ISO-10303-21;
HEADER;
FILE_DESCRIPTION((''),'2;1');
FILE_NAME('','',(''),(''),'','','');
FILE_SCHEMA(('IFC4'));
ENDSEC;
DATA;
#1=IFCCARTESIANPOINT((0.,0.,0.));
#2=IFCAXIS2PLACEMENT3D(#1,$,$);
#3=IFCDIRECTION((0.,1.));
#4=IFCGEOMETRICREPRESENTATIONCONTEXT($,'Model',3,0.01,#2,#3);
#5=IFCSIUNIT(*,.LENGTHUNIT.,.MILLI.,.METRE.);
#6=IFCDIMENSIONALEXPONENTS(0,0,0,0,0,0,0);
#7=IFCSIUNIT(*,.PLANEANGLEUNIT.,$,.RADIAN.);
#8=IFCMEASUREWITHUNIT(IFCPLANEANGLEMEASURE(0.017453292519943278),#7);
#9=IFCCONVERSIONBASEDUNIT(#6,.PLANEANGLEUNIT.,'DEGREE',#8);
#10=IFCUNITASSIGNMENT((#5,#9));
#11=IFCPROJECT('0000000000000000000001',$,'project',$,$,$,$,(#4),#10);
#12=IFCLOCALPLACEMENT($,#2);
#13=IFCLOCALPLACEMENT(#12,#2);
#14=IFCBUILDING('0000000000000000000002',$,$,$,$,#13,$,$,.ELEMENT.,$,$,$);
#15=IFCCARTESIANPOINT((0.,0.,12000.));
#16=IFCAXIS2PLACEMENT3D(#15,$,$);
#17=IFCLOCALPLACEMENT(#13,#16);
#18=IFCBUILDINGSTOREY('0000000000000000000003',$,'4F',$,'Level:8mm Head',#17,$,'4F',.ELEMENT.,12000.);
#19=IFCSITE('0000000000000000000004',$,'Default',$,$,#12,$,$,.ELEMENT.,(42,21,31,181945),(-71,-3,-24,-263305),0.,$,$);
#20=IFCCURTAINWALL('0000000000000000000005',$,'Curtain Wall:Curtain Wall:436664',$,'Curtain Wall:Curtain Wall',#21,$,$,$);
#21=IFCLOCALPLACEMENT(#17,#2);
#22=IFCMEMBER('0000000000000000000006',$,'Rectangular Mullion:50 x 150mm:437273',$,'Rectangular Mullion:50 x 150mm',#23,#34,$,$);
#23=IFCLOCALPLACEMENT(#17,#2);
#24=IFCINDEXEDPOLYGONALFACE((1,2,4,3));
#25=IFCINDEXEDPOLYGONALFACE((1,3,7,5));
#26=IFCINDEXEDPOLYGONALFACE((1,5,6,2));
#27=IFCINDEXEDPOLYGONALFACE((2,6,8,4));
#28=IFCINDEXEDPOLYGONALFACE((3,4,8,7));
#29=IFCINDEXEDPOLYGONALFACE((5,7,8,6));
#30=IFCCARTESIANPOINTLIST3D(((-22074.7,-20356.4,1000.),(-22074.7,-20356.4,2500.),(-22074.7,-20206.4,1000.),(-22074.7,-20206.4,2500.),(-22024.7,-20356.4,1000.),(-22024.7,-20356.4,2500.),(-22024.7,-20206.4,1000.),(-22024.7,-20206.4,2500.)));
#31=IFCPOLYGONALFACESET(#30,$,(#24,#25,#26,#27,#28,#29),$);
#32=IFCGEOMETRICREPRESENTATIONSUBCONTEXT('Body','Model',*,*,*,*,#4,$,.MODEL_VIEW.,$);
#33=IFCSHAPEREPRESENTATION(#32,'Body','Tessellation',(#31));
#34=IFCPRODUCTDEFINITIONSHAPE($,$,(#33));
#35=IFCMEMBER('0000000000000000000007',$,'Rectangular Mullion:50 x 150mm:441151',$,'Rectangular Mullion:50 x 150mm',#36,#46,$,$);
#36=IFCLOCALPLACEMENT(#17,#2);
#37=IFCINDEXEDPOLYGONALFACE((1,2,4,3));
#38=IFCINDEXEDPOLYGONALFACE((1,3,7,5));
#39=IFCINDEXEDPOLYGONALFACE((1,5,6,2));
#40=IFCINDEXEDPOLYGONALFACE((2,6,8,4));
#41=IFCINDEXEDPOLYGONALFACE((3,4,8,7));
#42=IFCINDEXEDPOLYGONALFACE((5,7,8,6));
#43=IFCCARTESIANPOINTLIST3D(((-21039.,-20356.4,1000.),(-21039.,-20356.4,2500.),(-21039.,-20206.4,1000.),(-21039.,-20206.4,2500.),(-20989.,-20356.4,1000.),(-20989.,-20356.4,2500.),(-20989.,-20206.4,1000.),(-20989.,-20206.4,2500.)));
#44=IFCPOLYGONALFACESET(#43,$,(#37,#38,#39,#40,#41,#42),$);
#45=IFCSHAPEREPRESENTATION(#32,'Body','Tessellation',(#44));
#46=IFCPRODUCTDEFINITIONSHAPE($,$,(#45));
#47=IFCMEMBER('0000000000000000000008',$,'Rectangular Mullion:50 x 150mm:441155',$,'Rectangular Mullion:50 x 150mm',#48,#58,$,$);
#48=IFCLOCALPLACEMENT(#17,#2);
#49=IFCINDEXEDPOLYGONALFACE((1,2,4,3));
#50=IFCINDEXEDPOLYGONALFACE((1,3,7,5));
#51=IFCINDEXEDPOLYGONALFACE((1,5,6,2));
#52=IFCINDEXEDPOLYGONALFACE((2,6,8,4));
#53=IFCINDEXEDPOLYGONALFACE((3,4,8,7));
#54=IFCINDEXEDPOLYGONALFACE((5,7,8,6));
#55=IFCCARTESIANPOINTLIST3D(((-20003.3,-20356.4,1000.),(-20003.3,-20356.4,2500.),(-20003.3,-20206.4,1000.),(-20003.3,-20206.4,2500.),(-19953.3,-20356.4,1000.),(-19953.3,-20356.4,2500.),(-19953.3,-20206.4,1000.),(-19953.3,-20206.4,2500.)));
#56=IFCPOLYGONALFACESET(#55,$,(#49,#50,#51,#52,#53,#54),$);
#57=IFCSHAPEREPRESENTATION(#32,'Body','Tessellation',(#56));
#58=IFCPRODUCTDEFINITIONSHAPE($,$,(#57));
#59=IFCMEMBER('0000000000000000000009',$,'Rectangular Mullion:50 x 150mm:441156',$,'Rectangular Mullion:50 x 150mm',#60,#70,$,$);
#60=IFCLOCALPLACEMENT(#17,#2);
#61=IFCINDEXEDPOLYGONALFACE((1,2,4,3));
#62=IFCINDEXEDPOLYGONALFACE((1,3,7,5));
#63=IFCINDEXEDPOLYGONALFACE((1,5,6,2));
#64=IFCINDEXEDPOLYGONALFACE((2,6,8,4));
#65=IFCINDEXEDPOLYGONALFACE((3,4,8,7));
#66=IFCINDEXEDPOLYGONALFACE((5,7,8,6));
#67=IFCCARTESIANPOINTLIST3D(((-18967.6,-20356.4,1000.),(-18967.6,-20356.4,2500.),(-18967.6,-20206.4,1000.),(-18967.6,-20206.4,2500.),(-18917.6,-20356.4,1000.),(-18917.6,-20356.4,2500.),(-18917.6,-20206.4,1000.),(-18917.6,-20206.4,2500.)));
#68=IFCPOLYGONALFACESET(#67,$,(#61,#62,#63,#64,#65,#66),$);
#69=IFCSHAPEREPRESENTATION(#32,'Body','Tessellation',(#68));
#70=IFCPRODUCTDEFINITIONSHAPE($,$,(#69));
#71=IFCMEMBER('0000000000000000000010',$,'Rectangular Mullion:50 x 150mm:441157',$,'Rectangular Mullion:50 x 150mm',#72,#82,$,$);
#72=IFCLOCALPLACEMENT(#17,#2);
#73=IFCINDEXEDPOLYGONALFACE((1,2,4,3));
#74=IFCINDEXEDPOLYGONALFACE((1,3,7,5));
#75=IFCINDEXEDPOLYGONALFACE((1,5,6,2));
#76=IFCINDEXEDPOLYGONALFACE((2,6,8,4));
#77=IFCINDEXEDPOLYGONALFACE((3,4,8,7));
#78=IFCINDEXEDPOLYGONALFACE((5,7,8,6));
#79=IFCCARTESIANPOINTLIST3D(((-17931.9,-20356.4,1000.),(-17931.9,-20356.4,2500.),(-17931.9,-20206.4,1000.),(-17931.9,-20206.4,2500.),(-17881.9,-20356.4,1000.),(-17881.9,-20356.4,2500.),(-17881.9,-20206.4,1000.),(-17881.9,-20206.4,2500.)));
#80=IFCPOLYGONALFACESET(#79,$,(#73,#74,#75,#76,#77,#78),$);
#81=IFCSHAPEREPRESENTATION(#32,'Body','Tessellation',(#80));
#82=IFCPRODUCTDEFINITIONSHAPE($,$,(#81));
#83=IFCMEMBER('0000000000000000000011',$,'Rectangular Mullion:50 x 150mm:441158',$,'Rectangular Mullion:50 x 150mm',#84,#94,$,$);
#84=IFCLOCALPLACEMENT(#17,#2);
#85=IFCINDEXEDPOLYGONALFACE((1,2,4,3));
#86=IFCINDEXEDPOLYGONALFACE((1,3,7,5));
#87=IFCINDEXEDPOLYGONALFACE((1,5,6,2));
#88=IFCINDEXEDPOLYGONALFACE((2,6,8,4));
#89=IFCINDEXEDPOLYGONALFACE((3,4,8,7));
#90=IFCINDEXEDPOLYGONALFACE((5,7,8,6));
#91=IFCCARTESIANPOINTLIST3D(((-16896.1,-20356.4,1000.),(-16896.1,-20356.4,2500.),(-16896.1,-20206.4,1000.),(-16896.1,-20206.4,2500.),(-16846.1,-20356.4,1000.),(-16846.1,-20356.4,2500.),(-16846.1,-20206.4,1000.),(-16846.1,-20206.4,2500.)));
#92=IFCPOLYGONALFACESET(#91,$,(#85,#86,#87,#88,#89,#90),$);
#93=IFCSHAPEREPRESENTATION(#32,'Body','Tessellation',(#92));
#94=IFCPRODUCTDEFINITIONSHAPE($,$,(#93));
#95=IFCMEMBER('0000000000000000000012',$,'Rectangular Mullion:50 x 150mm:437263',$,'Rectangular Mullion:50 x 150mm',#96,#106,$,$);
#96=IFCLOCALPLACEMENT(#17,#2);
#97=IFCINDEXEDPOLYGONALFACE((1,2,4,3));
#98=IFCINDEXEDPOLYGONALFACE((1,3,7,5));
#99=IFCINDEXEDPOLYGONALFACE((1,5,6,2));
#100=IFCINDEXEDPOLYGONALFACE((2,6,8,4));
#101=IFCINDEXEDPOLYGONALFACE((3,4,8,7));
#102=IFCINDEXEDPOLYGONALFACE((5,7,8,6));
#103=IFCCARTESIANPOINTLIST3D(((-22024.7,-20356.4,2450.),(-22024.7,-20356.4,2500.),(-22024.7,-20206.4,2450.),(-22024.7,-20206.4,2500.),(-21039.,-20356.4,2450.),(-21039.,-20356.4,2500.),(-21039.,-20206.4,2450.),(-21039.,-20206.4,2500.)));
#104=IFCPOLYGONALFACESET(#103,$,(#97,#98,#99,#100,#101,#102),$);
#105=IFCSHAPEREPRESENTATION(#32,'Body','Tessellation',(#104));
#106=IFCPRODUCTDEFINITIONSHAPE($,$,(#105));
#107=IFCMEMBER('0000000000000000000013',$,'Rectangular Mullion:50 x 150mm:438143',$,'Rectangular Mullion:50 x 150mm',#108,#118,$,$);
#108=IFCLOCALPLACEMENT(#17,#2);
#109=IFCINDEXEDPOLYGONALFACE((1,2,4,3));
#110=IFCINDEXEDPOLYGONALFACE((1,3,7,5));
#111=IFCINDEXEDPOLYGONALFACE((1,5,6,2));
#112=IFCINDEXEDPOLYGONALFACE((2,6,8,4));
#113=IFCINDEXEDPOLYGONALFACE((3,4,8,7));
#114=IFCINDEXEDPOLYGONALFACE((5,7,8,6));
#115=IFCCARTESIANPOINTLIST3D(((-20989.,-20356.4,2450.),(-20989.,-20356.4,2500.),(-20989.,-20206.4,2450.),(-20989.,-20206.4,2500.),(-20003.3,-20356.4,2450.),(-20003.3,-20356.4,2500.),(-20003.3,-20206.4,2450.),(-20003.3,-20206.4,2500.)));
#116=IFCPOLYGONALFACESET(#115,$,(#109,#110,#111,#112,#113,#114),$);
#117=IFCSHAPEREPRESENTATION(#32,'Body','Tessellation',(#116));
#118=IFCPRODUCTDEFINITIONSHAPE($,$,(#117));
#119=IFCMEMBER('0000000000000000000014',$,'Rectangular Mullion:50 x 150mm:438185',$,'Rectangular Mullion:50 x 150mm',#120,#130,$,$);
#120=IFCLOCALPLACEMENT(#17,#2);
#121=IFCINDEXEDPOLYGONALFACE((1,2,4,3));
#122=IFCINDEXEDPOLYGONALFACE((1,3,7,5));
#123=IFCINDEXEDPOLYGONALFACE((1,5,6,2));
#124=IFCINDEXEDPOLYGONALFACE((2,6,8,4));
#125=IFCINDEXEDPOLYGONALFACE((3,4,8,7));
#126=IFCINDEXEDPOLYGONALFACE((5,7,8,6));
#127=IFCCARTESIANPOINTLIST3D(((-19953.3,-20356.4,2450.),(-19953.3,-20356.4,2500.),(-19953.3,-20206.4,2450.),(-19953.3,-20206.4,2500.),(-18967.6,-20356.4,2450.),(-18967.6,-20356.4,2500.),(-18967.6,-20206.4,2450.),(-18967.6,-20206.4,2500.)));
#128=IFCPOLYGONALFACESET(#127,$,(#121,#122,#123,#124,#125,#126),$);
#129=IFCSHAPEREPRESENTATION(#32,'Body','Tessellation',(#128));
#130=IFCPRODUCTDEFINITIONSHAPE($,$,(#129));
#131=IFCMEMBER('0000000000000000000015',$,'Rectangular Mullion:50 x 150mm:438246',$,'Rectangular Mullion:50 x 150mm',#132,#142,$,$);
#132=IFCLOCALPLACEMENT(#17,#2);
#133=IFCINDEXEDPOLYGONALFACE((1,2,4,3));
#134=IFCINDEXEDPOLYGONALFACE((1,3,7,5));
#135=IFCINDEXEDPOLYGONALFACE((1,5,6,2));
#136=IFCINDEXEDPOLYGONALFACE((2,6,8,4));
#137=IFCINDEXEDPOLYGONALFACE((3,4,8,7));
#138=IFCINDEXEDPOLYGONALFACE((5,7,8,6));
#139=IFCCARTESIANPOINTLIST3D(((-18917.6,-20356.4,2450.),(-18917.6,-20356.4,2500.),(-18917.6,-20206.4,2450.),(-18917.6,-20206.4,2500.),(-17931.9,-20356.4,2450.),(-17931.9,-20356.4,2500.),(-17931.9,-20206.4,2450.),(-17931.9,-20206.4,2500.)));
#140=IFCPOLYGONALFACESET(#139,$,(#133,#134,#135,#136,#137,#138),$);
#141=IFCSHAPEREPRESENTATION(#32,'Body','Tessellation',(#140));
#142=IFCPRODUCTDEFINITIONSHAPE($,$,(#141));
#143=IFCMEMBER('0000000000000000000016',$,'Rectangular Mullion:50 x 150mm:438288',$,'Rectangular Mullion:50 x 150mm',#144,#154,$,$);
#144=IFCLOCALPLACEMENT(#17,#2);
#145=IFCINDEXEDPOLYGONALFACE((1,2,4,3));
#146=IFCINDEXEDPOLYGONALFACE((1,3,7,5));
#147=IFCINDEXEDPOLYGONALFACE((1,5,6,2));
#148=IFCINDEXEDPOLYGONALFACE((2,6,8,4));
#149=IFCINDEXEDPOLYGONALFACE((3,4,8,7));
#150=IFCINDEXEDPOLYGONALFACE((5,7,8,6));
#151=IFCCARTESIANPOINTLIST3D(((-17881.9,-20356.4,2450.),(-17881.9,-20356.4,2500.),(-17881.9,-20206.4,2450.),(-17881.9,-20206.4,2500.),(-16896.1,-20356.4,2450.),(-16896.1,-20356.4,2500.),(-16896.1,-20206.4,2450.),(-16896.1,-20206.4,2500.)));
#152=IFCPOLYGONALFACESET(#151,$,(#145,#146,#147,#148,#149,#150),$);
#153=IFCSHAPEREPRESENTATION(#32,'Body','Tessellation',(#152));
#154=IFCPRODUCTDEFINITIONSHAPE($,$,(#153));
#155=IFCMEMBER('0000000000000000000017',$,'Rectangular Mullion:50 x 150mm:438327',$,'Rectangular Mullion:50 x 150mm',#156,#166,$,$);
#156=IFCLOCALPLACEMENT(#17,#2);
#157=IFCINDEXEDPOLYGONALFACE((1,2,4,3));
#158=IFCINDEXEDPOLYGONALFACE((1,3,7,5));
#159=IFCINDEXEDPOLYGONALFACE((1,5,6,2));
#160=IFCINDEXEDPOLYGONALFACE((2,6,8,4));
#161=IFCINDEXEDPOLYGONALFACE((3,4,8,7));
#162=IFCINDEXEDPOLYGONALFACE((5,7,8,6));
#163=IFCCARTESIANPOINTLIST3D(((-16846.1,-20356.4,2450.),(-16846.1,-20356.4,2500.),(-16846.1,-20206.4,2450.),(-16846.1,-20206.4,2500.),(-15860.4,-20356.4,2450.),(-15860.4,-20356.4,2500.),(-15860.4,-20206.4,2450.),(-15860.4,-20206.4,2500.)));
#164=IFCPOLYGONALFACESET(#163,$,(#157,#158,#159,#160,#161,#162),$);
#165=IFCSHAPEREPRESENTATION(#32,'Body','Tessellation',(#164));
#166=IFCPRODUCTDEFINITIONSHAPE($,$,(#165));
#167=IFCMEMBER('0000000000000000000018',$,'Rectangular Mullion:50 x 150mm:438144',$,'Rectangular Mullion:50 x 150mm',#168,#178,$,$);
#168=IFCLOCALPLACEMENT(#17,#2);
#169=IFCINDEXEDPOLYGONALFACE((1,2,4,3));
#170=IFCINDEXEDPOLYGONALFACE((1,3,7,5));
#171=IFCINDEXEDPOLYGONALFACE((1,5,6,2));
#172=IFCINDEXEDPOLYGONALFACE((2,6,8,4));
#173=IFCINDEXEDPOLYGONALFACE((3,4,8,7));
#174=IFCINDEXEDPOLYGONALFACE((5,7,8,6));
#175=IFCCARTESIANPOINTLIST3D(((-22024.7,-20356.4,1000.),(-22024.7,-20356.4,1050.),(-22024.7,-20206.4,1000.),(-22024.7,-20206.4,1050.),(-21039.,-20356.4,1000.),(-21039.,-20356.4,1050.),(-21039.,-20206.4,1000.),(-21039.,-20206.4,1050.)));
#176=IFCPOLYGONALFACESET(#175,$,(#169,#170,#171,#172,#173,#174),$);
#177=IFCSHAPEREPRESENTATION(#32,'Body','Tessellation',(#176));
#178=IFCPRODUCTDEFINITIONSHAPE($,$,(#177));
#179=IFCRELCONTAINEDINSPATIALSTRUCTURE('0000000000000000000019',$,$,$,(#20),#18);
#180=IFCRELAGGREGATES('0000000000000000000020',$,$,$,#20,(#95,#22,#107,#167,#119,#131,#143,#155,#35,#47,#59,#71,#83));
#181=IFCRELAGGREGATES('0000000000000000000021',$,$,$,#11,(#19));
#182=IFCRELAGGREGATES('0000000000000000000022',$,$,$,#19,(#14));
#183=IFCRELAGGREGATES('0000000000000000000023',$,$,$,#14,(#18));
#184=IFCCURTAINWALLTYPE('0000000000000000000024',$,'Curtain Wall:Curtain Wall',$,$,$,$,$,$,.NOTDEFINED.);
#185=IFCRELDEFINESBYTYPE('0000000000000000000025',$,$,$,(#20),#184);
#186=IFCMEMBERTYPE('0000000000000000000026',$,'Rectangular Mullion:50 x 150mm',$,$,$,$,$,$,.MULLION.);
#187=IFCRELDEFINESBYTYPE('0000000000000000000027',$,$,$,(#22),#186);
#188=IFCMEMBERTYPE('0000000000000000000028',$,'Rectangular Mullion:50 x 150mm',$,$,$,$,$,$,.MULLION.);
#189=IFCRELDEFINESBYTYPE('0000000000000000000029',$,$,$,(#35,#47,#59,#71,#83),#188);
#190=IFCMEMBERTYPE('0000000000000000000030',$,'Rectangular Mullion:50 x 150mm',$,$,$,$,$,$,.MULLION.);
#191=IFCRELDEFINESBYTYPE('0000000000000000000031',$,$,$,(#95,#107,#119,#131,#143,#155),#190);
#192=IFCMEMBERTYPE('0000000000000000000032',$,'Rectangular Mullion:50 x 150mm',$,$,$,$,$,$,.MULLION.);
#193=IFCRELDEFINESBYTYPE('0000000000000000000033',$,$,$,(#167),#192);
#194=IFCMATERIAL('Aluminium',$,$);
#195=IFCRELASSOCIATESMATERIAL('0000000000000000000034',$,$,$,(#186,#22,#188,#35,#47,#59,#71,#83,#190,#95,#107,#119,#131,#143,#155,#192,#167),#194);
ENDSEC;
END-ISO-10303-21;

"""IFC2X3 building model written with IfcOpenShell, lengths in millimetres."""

from ifc_helpers import new_model, entity, si_unit, converted_unit, direction, frame, origin, origin_2d_with_axis, place, context, subcontext, project, spatial, rectangle, extrude, source, transform, mapped, material, type_object, type_shapes, element, aggregate, save


model = new_model("IFC2X3")

# Units and contexts
model_context = context("Model", 3, precision=0.01, world=origin(), true_north=direction((0.0, 1.0)))
body_context = subcontext(model_context, "Body", "Model", "MODEL_VIEW")
ifc_project = project(units=[si_unit("LENGTHUNIT", "METRE", prefix="MILLI"), converted_unit("PLANEANGLEUNIT", "DEGREE", entity("IfcPlaneAngleMeasure", 0.017453292519943278), si_unit("PLANEANGLEUNIT", "RADIAN"), dimensions=[0, 0, 0, 0, 0, 0, 0])], contexts=[model_context])

# Site, building, storey
site_placement = place(None, origin())
site = spatial("IfcSite", under=ifc_project, at=site_placement, Name="Default", CompositionType="ELEMENT", RefLatitude=(42, 21, 31, 181945), RefLongitude=(-71, -3, -24, -263305), RefElevation=0.0)
building_placement = place(site_placement, origin())
building = spatial("IfcBuilding", under=site, at=building_placement, CompositionType="ELEMENT")
storey_placement = place(building_placement, frame((0.0, 0.0, 12000.0)))
storey = spatial("IfcBuildingStorey", under=building, at=storey_placement, Name="4F", ObjectType="Level:8mm Head", LongName="4F", CompositionType="ELEMENT", Elevation=12000.0)

# Curtain wall, members
curtain_wall_type = type_object("IfcCurtainWallType", Name="Curtain Wall:Curtain Wall", PredefinedType="NOTDEFINED")
curtain_wall_placement = place(storey_placement, frame((0.0, 0.0, -12000.0)))
curtain_wall = element("IfcCurtainWall", 1, at=curtain_wall_placement, inside=storey, type_object=curtain_wall_type, Name="Curtain Wall:Curtain Wall:436664", ObjectType="Curtain Wall:Curtain Wall")
ifc_material_1 = material(Name="Aluminium")
member_type_1 = type_object("IfcMemberType", Name="Rectangular Mullion:50 x 150mm", PredefinedType="MULLION", material=ifc_material_1)
shared_shape_1 = source(origin(), body_context, "Body", "SweptSolid", [
    extrude(rectangle(XDim=50.0, YDim=150.0, at=origin_2d_with_axis()), frame((-25.0, 0.0, -1500.0), z_axis=(0.0, 0.0, 1.0), x_axis=(-1.0, 0.0, 0.0)), (0.0, 0.0, 1.0), 1500.0),
])
type_shapes(member_type_1, [shared_shape_1])
member_1_placement = place(curtain_wall_placement, frame((-22074.7, -20281.4, 13000.0), z_axis=(0.0, 0.0, -1.0), x_axis=(-1.0, 0.0, 0.0)))
member_1 = element("IfcMember", 2, at=member_1_placement, type_object=member_type_1, material=ifc_material_1, Name="Rectangular Mullion:50 x 150mm:437273", ObjectType="Rectangular Mullion:50 x 150mm", context=body_context, shape_type="MappedRepresentation", body=[
    mapped(shared_shape_1, transform((0.0, 0.0, 0.0), scale=1.0)),
])
member_type_2 = type_object("IfcMemberType", Name="Rectangular Mullion:50 x 150mm", PredefinedType="MULLION", material=ifc_material_1)
shared_shape_2 = source(origin(), body_context, "Body", "SweptSolid", [
    extrude(rectangle(XDim=50.0, YDim=150.0, at=origin_2d_with_axis()), frame((0.0, 0.0, -1500.0), z_axis=(0.0, 0.0, 1.0), x_axis=(-1.0, 0.0, 0.0)), (0.0, 0.0, 1.0), 1500.0),
])
type_shapes(member_type_2, [shared_shape_2])
member_2_placement = place(curtain_wall_placement, frame((-21014.0, -20281.4, 13000.0), z_axis=(0.0, 0.0, -1.0), x_axis=(-1.0, 0.0, 0.0)))
member_2 = element("IfcMember", 3, at=member_2_placement, type_object=member_type_2, material=ifc_material_1, Name="Rectangular Mullion:50 x 150mm:441151", ObjectType="Rectangular Mullion:50 x 150mm", context=body_context, shape_type="MappedRepresentation", body=[
    mapped(shared_shape_2, transform((0.0, 0.0, 0.0), scale=1.0)),
])
member_3_placement = place(curtain_wall_placement, frame((-19978.3, -20281.4, 13000.0), z_axis=(0.0, 0.0, -1.0), x_axis=(-1.0, 0.0, 0.0)))
member_3 = element("IfcMember", 4, at=member_3_placement, type_object=member_type_2, material=ifc_material_1, Name="Rectangular Mullion:50 x 150mm:441155", ObjectType="Rectangular Mullion:50 x 150mm", context=body_context, shape_type="MappedRepresentation", body=[
    mapped(shared_shape_2, transform((0.0, 0.0, 0.0), scale=1.0)),
])
member_4_placement = place(curtain_wall_placement, frame((-18942.6, -20281.4, 13000.0), z_axis=(0.0, 0.0, -1.0), x_axis=(-1.0, 0.0, 0.0)))
member_4 = element("IfcMember", 5, at=member_4_placement, type_object=member_type_2, material=ifc_material_1, Name="Rectangular Mullion:50 x 150mm:441156", ObjectType="Rectangular Mullion:50 x 150mm", context=body_context, shape_type="MappedRepresentation", body=[
    mapped(shared_shape_2, transform((0.0, 0.0, 0.0), scale=1.0)),
])
member_5_placement = place(curtain_wall_placement, frame((-17906.9, -20281.4, 13000.0), z_axis=(0.0, 0.0, -1.0), x_axis=(-1.0, 0.0, 0.0)))
member_5 = element("IfcMember", 6, at=member_5_placement, type_object=member_type_2, material=ifc_material_1, Name="Rectangular Mullion:50 x 150mm:441157", ObjectType="Rectangular Mullion:50 x 150mm", context=body_context, shape_type="MappedRepresentation", body=[
    mapped(shared_shape_2, transform((0.0, 0.0, 0.0), scale=1.0)),
])
member_6_placement = place(curtain_wall_placement, frame((-16871.1, -20281.4, 13000.0), z_axis=(0.0, 0.0, -1.0), x_axis=(-1.0, 0.0, 0.0)))
member_6 = element("IfcMember", 7, at=member_6_placement, type_object=member_type_2, material=ifc_material_1, Name="Rectangular Mullion:50 x 150mm:441158", ObjectType="Rectangular Mullion:50 x 150mm", context=body_context, shape_type="MappedRepresentation", body=[
    mapped(shared_shape_2, transform((0.0, 0.0, 0.0), scale=1.0)),
])
member_type_3 = type_object("IfcMemberType", Name="Rectangular Mullion:50 x 150mm", PredefinedType="MULLION", material=ifc_material_1)
shared_shape_3 = source(origin(), body_context, "Body", "SweptSolid", [
    extrude(rectangle(XDim=50.0, YDim=150.0, at=origin_2d_with_axis()), frame((-25.0, 0.0, -985.7), z_axis=(0.0, 0.0, 1.0), x_axis=(-1.0, 0.0, 0.0)), (0.0, 0.0, 1.0), 985.7),
])
type_shapes(member_type_3, [shared_shape_3])
member_7_placement = place(curtain_wall_placement, frame((-22024.7, -20281.4, 14500.0), z_axis=(-1.0, 0.0, 0.0), x_axis=(0.0, 0.0, 1.0)))
member_7 = element("IfcMember", 8, at=member_7_placement, type_object=member_type_3, material=ifc_material_1, Name="Rectangular Mullion:50 x 150mm:437263", ObjectType="Rectangular Mullion:50 x 150mm", context=body_context, shape_type="MappedRepresentation", body=[
    mapped(shared_shape_3, transform((0.0, 0.0, 0.0), scale=1.0)),
])
member_8_placement = place(curtain_wall_placement, frame((-20989.0, -20281.4, 14500.0), z_axis=(-1.0, 0.0, 0.0), x_axis=(0.0, 0.0, 1.0)))
member_8 = element("IfcMember", 9, at=member_8_placement, type_object=member_type_3, material=ifc_material_1, Name="Rectangular Mullion:50 x 150mm:438143", ObjectType="Rectangular Mullion:50 x 150mm", context=body_context, shape_type="MappedRepresentation", body=[
    mapped(shared_shape_3, transform((0.0, 0.0, 0.0), scale=1.0)),
])
member_9_placement = place(curtain_wall_placement, frame((-19953.3, -20281.4, 14500.0), z_axis=(-1.0, 0.0, 0.0), x_axis=(0.0, 0.0, 1.0)))
member_9 = element("IfcMember", 10, at=member_9_placement, type_object=member_type_3, material=ifc_material_1, Name="Rectangular Mullion:50 x 150mm:438185", ObjectType="Rectangular Mullion:50 x 150mm", context=body_context, shape_type="MappedRepresentation", body=[
    mapped(shared_shape_3, transform((0.0, 0.0, 0.0), scale=1.0)),
])
member_10_placement = place(curtain_wall_placement, frame((-18917.6, -20281.4, 14500.0), z_axis=(-1.0, 0.0, 0.0), x_axis=(0.0, 0.0, 1.0)))
member_10 = element("IfcMember", 11, at=member_10_placement, type_object=member_type_3, material=ifc_material_1, Name="Rectangular Mullion:50 x 150mm:438246", ObjectType="Rectangular Mullion:50 x 150mm", context=body_context, shape_type="MappedRepresentation", body=[
    mapped(shared_shape_3, transform((0.0, 0.0, 0.0), scale=1.0)),
])
member_11_placement = place(curtain_wall_placement, frame((-17881.9, -20281.4, 14500.0), z_axis=(-1.0, 0.0, 0.0), x_axis=(0.0, 0.0, 1.0)))
member_11 = element("IfcMember", 12, at=member_11_placement, type_object=member_type_3, material=ifc_material_1, Name="Rectangular Mullion:50 x 150mm:438288", ObjectType="Rectangular Mullion:50 x 150mm", context=body_context, shape_type="MappedRepresentation", body=[
    mapped(shared_shape_3, transform((0.0, 0.0, 0.0), scale=1.0)),
])
member_12_placement = place(curtain_wall_placement, frame((-16846.1, -20281.4, 14500.0), z_axis=(-1.0, 0.0, 0.0), x_axis=(0.0, 0.0, 1.0)))
member_12 = element("IfcMember", 13, at=member_12_placement, type_object=member_type_3, material=ifc_material_1, Name="Rectangular Mullion:50 x 150mm:438327", ObjectType="Rectangular Mullion:50 x 150mm", context=body_context, shape_type="MappedRepresentation", body=[
    mapped(shared_shape_3, transform((0.0, 0.0, 0.0), scale=1.0)),
])
member_type_4 = type_object("IfcMemberType", Name="Rectangular Mullion:50 x 150mm", PredefinedType="MULLION", material=ifc_material_1)
shared_shape_4 = source(origin(), body_context, "Body", "SweptSolid", [
    extrude(rectangle(XDim=50.0, YDim=150.0, at=origin_2d_with_axis()), frame((-25.0, 0.0, -985.7), z_axis=(0.0, 0.0, 1.0), x_axis=(-1.0, 0.0, 0.0)), (0.0, 0.0, 1.0), 985.7),
])
type_shapes(member_type_4, [shared_shape_4])
member_13_placement = place(curtain_wall_placement, frame((-21039.0, -20281.4, 13000.0), z_axis=(1.0, 0.0, 0.0), x_axis=(0.0, 0.0, -1.0)))
member_13 = element("IfcMember", 14, at=member_13_placement, type_object=member_type_4, material=ifc_material_1, Name="Rectangular Mullion:50 x 150mm:438144", ObjectType="Rectangular Mullion:50 x 150mm", context=body_context, shape_type="MappedRepresentation", body=[
    mapped(shared_shape_4, transform((0.0, 0.0, 0.0), scale=1.0)),
])

aggregate(curtain_wall, [member_7, member_1, member_8, member_13, member_9, member_10, member_11, member_12, member_2, member_3, member_4, member_5, member_6])

save(model, "model.ifc")
